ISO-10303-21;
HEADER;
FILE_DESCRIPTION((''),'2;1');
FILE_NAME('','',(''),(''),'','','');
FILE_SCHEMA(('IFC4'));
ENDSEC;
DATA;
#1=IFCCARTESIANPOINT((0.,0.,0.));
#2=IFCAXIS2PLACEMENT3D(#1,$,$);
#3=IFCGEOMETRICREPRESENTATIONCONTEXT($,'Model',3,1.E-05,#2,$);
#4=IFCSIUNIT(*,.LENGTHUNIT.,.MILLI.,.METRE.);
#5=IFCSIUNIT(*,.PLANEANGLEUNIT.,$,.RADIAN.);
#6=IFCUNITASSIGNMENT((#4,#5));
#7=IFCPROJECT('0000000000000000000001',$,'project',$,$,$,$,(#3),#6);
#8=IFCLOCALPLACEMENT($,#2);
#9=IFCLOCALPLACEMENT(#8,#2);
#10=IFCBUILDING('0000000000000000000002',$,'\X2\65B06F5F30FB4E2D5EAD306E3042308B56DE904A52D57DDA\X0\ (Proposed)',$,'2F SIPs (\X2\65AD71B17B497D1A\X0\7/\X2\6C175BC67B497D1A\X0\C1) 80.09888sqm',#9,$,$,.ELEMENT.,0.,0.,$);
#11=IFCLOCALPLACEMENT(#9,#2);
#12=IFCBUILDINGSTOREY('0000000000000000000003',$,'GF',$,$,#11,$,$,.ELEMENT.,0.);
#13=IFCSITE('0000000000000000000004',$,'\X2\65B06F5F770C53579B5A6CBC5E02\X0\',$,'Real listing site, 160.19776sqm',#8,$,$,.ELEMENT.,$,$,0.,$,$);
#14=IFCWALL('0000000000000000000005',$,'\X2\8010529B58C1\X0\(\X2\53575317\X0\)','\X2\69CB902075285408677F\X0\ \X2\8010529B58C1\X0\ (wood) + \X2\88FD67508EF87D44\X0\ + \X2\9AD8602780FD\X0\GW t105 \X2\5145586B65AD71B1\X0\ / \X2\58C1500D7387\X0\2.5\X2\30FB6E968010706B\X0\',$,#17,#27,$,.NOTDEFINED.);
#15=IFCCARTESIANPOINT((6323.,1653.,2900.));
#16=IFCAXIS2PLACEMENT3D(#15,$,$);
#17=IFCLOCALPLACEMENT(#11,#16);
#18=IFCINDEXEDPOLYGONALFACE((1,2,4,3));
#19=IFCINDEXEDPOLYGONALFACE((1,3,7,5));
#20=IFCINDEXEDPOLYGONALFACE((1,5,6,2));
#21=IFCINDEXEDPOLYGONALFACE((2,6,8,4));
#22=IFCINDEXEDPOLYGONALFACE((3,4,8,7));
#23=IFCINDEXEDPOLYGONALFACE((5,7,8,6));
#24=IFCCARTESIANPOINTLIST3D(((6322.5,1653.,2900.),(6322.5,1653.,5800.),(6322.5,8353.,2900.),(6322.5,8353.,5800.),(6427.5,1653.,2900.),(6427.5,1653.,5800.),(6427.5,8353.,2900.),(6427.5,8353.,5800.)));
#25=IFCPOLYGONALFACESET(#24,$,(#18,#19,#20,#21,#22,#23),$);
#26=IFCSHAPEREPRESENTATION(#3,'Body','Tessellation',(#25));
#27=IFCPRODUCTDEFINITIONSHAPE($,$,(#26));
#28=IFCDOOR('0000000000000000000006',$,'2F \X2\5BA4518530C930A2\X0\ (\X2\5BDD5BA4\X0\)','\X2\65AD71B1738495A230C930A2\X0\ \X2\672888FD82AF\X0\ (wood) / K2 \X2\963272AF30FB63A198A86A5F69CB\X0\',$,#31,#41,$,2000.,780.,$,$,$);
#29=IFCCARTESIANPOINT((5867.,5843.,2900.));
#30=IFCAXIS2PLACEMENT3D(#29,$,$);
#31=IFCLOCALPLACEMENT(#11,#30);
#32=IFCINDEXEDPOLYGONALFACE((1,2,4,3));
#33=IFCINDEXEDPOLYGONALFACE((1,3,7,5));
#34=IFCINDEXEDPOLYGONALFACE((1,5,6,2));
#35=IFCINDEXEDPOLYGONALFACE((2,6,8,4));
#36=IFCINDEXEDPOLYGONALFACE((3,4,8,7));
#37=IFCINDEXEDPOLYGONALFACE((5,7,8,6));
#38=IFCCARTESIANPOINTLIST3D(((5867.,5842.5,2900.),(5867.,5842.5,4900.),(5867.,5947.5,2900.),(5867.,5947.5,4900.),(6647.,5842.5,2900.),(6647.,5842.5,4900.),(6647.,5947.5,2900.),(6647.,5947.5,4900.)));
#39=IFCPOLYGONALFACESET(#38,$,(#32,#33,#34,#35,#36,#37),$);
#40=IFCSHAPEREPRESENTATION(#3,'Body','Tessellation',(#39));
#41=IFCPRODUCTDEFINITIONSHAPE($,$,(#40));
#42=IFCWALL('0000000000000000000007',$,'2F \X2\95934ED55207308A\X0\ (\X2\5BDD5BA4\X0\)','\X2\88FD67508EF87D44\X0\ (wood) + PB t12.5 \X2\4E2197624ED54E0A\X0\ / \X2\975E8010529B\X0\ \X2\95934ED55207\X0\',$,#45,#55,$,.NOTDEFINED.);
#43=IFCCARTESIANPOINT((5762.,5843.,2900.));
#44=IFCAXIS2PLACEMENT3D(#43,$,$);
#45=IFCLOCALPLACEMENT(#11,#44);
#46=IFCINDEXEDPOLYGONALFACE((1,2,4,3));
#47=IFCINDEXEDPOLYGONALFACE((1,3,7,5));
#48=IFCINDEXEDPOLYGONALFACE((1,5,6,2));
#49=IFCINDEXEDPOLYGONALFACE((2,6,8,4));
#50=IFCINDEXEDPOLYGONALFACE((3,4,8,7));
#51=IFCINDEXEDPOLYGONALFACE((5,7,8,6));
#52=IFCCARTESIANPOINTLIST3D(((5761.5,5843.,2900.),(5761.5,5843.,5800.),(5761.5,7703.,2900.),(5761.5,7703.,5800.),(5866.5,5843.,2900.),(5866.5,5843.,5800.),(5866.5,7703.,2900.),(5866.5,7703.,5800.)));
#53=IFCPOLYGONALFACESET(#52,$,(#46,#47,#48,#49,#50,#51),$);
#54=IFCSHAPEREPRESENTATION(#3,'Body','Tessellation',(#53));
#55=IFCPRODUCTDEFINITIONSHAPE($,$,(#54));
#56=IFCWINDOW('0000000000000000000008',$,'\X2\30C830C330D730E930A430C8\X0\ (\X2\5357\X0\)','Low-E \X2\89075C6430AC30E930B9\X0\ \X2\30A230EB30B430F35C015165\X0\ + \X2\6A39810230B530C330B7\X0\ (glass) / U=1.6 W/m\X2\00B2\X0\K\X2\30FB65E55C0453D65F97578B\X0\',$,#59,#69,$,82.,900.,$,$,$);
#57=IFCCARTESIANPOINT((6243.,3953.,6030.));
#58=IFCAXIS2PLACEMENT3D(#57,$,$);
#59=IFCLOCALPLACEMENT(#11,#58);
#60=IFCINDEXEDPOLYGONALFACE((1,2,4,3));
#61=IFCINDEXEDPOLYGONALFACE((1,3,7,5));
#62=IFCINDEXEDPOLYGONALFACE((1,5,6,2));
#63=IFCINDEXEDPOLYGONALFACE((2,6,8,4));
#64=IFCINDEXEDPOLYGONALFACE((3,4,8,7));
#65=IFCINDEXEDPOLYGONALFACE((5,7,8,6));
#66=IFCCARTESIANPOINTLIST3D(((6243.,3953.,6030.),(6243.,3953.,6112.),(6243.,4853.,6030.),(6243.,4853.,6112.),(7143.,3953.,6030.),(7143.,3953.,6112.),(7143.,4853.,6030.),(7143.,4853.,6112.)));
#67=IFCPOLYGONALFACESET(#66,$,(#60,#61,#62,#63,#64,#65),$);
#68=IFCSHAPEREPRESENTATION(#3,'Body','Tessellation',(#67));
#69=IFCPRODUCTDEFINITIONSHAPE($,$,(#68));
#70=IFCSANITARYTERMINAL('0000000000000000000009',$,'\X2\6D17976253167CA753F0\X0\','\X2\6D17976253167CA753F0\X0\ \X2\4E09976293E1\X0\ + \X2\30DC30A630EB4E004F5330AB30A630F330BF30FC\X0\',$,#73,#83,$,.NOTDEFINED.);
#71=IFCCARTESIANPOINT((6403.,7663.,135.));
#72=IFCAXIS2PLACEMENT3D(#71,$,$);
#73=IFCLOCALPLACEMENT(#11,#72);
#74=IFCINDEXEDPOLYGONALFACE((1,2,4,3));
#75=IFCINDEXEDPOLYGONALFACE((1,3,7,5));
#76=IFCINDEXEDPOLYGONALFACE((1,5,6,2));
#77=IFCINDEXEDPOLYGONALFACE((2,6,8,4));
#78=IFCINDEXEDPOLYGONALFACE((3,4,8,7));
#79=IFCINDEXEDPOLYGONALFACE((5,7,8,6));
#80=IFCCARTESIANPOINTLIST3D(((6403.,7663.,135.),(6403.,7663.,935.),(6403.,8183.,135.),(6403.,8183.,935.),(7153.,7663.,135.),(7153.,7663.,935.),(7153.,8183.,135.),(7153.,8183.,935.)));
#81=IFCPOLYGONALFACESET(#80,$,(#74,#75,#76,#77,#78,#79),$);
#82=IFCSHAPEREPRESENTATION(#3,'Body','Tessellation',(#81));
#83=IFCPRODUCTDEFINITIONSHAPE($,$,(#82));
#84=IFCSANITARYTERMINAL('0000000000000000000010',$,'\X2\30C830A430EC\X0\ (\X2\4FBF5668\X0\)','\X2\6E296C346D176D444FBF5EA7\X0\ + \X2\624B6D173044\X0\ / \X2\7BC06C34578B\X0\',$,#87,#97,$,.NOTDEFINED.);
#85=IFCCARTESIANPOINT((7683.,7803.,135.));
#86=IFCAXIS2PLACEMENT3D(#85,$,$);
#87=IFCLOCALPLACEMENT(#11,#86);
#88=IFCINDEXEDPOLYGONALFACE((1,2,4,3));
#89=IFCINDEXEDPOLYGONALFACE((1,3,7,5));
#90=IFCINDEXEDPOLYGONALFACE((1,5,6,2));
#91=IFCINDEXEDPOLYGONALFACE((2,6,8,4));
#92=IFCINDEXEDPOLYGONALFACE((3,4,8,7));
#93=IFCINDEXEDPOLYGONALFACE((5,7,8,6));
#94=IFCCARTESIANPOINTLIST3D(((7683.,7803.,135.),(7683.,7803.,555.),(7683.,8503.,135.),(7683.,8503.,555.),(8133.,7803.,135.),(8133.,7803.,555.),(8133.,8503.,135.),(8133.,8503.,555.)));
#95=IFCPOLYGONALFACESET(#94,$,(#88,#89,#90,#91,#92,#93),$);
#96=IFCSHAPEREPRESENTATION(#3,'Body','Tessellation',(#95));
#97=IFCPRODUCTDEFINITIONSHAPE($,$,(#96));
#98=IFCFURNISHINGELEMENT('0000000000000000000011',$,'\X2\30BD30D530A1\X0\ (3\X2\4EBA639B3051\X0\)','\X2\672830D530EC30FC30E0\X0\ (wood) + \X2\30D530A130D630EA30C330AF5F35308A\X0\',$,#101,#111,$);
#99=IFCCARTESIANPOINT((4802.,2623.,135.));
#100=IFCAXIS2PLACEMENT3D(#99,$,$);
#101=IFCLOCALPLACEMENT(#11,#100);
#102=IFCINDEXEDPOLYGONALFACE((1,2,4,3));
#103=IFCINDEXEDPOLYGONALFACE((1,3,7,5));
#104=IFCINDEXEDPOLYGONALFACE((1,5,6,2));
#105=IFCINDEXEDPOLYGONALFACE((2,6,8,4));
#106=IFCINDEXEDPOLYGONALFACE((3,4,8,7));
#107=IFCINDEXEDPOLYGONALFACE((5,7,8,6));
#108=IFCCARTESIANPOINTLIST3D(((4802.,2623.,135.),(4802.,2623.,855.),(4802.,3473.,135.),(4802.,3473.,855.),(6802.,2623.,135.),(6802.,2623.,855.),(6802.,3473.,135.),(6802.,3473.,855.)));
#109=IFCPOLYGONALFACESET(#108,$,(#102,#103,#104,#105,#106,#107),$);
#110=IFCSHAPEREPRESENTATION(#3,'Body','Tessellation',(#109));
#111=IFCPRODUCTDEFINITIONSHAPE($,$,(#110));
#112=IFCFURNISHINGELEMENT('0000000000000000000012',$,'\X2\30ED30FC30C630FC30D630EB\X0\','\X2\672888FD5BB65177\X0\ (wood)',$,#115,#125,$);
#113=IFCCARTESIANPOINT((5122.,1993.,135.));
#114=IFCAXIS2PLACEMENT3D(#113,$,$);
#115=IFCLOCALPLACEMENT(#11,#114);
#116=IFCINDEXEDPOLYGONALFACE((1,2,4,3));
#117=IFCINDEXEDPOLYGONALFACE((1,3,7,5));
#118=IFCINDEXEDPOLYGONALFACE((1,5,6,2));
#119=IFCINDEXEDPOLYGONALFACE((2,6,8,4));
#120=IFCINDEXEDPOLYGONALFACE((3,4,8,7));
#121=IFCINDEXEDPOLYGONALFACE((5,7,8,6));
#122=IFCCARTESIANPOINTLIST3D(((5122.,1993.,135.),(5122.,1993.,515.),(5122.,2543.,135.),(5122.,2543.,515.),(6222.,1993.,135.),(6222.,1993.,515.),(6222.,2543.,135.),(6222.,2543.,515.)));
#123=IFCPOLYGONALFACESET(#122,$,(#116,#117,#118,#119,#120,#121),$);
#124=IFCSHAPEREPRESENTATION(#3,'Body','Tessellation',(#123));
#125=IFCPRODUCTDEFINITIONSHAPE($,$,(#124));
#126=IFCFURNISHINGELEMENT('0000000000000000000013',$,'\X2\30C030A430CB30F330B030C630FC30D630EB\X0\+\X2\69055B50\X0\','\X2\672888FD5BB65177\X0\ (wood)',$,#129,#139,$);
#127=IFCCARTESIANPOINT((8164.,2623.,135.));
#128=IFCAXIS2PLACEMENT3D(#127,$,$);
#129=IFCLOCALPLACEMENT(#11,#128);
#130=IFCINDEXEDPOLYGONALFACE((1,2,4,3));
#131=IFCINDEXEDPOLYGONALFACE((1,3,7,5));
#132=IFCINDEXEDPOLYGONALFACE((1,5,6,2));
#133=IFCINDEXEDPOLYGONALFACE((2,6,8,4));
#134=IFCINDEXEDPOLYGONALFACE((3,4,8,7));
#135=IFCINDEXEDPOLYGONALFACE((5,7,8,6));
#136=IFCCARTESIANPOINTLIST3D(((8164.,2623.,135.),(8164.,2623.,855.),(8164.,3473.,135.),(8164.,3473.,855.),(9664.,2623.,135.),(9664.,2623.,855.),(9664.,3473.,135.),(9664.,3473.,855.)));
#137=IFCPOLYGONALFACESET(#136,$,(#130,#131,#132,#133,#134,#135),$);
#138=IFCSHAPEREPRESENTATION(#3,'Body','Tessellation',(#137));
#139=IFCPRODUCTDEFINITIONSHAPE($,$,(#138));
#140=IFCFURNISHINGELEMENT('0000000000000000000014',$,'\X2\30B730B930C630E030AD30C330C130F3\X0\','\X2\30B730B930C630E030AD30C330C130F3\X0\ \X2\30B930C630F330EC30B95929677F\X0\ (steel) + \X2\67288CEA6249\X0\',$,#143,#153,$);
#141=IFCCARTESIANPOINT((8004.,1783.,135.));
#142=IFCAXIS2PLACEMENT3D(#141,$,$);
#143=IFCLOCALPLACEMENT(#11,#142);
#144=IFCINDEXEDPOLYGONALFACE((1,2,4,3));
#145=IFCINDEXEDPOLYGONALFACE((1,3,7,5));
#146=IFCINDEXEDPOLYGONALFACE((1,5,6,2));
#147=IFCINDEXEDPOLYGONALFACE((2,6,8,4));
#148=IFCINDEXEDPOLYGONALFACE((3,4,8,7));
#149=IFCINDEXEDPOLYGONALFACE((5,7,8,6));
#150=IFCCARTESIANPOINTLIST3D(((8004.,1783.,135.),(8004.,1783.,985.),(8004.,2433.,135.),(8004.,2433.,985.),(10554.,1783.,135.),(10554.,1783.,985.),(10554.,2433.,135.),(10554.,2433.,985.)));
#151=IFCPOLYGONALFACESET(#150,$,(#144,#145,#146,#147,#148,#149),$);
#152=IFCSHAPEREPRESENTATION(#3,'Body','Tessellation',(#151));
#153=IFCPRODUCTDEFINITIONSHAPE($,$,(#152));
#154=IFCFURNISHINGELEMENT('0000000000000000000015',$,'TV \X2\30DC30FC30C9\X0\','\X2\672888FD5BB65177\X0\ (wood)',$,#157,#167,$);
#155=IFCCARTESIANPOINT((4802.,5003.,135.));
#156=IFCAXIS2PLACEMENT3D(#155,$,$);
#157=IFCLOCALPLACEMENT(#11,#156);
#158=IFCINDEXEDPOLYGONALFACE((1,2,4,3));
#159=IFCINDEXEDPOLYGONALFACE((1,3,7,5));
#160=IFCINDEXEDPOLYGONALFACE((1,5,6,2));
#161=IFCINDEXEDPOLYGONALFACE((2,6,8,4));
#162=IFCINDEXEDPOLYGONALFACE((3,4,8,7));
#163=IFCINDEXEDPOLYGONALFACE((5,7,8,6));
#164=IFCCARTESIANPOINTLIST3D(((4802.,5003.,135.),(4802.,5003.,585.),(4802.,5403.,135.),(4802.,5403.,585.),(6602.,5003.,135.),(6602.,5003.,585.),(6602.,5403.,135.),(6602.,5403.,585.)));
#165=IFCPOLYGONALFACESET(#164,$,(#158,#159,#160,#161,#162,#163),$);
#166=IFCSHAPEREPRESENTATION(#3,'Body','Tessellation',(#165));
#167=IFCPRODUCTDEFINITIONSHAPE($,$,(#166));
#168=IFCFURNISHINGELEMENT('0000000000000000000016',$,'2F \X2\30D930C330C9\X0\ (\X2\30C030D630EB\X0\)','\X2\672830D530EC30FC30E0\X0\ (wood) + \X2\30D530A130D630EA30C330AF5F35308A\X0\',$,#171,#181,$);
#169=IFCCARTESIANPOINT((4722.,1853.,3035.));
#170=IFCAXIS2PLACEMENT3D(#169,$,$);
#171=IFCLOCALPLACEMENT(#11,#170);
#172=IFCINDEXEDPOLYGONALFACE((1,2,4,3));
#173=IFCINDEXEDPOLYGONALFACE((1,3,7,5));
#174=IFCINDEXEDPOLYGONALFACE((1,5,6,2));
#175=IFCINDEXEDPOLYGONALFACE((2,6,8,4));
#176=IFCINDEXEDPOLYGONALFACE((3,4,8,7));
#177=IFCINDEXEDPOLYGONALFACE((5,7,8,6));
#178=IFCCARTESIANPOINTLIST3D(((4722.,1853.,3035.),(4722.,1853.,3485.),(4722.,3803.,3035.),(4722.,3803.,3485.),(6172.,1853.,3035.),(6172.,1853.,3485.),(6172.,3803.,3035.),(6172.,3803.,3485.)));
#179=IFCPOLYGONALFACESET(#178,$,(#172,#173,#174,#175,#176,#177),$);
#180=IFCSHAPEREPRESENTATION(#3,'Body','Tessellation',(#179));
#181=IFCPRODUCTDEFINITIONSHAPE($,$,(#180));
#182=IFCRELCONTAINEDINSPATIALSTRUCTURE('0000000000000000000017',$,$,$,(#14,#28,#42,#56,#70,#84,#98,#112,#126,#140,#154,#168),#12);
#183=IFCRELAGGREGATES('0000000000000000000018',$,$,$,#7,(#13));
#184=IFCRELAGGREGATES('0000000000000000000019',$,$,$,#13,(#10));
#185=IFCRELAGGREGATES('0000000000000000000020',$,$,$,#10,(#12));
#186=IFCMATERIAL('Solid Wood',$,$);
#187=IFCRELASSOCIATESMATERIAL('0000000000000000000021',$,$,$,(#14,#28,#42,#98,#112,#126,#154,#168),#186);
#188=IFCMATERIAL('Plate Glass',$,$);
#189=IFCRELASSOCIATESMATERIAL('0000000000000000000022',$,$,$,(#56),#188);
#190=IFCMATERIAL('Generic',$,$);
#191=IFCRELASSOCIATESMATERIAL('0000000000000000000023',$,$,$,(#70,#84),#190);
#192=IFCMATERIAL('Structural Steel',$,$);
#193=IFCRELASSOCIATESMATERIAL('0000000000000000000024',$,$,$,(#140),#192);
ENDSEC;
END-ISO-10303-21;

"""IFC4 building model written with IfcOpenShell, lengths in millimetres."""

from ifc_helpers import new_model, si_unit, frame, frame_2d, origin, place, context, project, spatial, rectangle, extrude, material, element, fill, save


model = new_model("IFC4")

# Units and contexts
model_context = context("Model", 3, precision=1e-05, world=origin())
ifc_project = project(units=[si_unit("LENGTHUNIT", "METRE", prefix="MILLI"), si_unit("PLANEANGLEUNIT", "RADIAN")], contexts=[model_context])

# Site, building, storey
site_placement = place(None, origin())
site = spatial("IfcSite", under=ifc_project, at=site_placement, Name="新潟県南魚沼市", ObjectType="Real listing site, 160.19776sqm", CompositionType="ELEMENT", RefElevation=0.0)
building_placement = place(site_placement, origin())
building = spatial("IfcBuilding", under=site, at=building_placement, Name="新潟・中庭のある回遊動線 (Proposed)", ObjectType="2F SIPs (断熱等級7/気密等級C1) 80.09888sqm", CompositionType="ELEMENT", ElevationOfRefHeight=0.0, ElevationOfTerrain=0.0)
storey_placement = place(building_placement, origin())
storey = spatial("IfcBuildingStorey", under=building, at=storey_placement, Name="GF", CompositionType="ELEMENT", Elevation=0.0)

# Shared definitions
ifc_material_1 = material(Name="Solid Wood")

# Wall, opening, door
wall_1_placement = place(storey_placement, frame((6323.0, 1653.0, 2900.0)))
wall_1 = element("IfcWall", 1, at=wall_1_placement, inside=storey, material=ifc_material_1, Name="耐力壁(南北)", Description="構造用合板 耐力壁 (wood) + 製材軸組 + 高性能GW t105 充填断熱 / 壁倍率2.5・準耐火", PredefinedType="NOTDEFINED", context=model_context, shape_type="SweptSolid", body=[
    extrude(rectangle(XDim=105.0, YDim=6700.0, at=frame_2d((52.0, 3350.0))), frame((6323.0, 1653.0, 2900.0)), (0.0, 0.0, 1.0), 2900.0),
])
opening_1_placement = place(storey_placement, frame((5867.0, 5843.0, 2900.0)))
opening_1 = element("IfcOpeningElement", 2, at=opening_1_placement, cuts=wall_1, PredefinedType="NOTDEFINED", context=model_context, shape_type="SweptSolid", body=[
    extrude(rectangle(XDim=780.0, YDim=105.0, at=frame_2d((390.0, 52.0))), frame((5867.0, 5843.0, 2900.0)), (0.0, 0.0, 1.0), 2000.0),
])
door_1_placement = place(storey_placement, frame((5867.0, 5843.0, 2900.0)))
door_1 = element("IfcDoor", 3, at=door_1_placement, inside=storey, material=ifc_material_1, Name="2F 室内ドア (寝室)", Description="断熱玄関ドア 木製芯 (wood) / K2 防犯・採風機構", OverallHeight=2000.0, OverallWidth=780.0, context=model_context, shape_type="SweptSolid", body=[
    extrude(rectangle(XDim=780.0, YDim=105.0, at=frame_2d((390.0, 52.0))), frame((5867.0, 5843.0, 2900.0)), (0.0, 0.0, 1.0), 2000.0),
])
fill(opening_1, door_1)

# Wall
wall_2_placement = place(storey_placement, frame((5762.0, 5843.0, 2900.0)))
element("IfcWall", 4, at=wall_2_placement, inside=storey, material=ifc_material_1, Name="2F 間仕切り (寝室)", Description="製材軸組 (wood) + PB t12.5 両面仕上 / 非耐力 間仕切", PredefinedType="NOTDEFINED", context=model_context, shape_type="SweptSolid", body=[
    extrude(rectangle(XDim=105.0, YDim=1860.0, at=frame_2d((52.0, 930.0))), frame((5762.0, 5843.0, 2900.0)), (0.0, 0.0, 1.0), 2900.0),
])

# Window
ifc_material_2 = material(Name="Plate Glass")
window_placement = place(storey_placement, frame((6243.0, 3953.0, 6030.0)))
element("IfcWindow", 5, at=window_placement, inside=storey, material=ifc_material_2, Name="トップライト (南)", Description="Low-E 複層ガラス アルゴン封入 + 樹脂サッシ (glass) / U=1.6 W/m²K・日射取得型", OverallHeight=82.0, OverallWidth=900.0, context=model_context, shape_type="SweptSolid", body=[
    extrude(rectangle(XDim=900.0, YDim=900.0, at=frame_2d((450.0, 450.0))), frame((6243.0, 3953.0, 6030.0)), (0.0, 0.0, 1.0), 82.0),
])

# Sanitary terminals
ifc_material_3 = material(Name="Generic")
sanitary_terminal_1_placement = place(storey_placement, frame((6403.0, 7663.0, 135.0)))
element("IfcSanitaryTerminal", 6, at=sanitary_terminal_1_placement, inside=storey, material=ifc_material_3, Name="洗面化粧台", Description="洗面化粧台 三面鏡 + ボウル一体カウンター", PredefinedType="NOTDEFINED", context=model_context, shape_type="SweptSolid", body=[
    extrude(rectangle(XDim=750.0, YDim=520.0, at=frame_2d((375.0, 260.0))), frame((6403.0, 7663.0, 135.0)), (0.0, 0.0, 1.0), 800.0),
])
sanitary_terminal_2_placement = place(storey_placement, frame((7683.0, 7803.0, 135.0)))
element("IfcSanitaryTerminal", 7, at=sanitary_terminal_2_placement, inside=storey, material=ifc_material_3, Name="トイレ (便器)", Description="温水洗浄便座 + 手洗い / 節水型", PredefinedType="NOTDEFINED", context=model_context, shape_type="SweptSolid", body=[
    extrude(rectangle(XDim=450.0, YDim=700.0, at=frame_2d((225.0, 350.0))), frame((7683.0, 7803.0, 135.0)), (0.0, 0.0, 1.0), 420.0),
])

# Furnishing elements
furnishing_1_placement = place(storey_placement, frame((4802.0, 2623.0, 135.0)))
element("IfcFurnishingElement", 8, at=furnishing_1_placement, inside=storey, material=ifc_material_1, Name="ソファ (3人掛け)", Description="木フレーム (wood) + ファブリック張り", context=model_context, shape_type="SweptSolid", body=[
    extrude(rectangle(XDim=2000.0, YDim=850.0, at=frame_2d((1000.0, 425.0))), frame((4802.0, 2623.0, 135.0)), (0.0, 0.0, 1.0), 720.0),
])
furnishing_2_placement = place(storey_placement, frame((5122.0, 1993.0, 135.0)))
element("IfcFurnishingElement", 9, at=furnishing_2_placement, inside=storey, material=ifc_material_1, Name="ローテーブル", Description="木製家具 (wood)", context=model_context, shape_type="SweptSolid", body=[
    extrude(rectangle(XDim=1100.0, YDim=550.0, at=frame_2d((550.0, 275.0))), frame((5122.0, 1993.0, 135.0)), (0.0, 0.0, 1.0), 380.0),
])
furnishing_3_placement = place(storey_placement, frame((8164.0, 2623.0, 135.0)))
element("IfcFurnishingElement", 10, at=furnishing_3_placement, inside=storey, material=ifc_material_1, Name="ダイニングテーブル+椅子", Description="木製家具 (wood)", context=model_context, shape_type="SweptSolid", body=[
    extrude(rectangle(XDim=1500.0, YDim=850.0, at=frame_2d((750.0, 425.0))), frame((8164.0, 2623.0, 135.0)), (0.0, 0.0, 1.0), 720.0),
])
ifc_material_4 = material(Name="Structural Steel")
furnishing_4_placement = place(storey_placement, frame((8004.0, 1783.0, 135.0)))
element("IfcFurnishingElement", 11, at=furnishing_4_placement, inside=storey, material=ifc_material_4, Name="システムキッチン", Description="システムキッチン ステンレス天板 (steel) + 木質扉", context=model_context, shape_type="SweptSolid", body=[
    extrude(rectangle(XDim=2550.0, YDim=650.0, at=frame_2d((1275.0, 325.0))), frame((8004.0, 1783.0, 135.0)), (0.0, 0.0, 1.0), 850.0),
])
furnishing_5_placement = place(storey_placement, frame((4802.0, 5003.0, 135.0)))
element("IfcFurnishingElement", 12, at=furnishing_5_placement, inside=storey, material=ifc_material_1, Name="TV ボード", Description="木製家具 (wood)", context=model_context, shape_type="SweptSolid", body=[
    extrude(rectangle(XDim=1800.0, YDim=400.0, at=frame_2d((900.0, 200.0))), frame((4802.0, 5003.0, 135.0)), (0.0, 0.0, 1.0), 450.0),
])
furnishing_6_placement = place(storey_placement, frame((4722.0, 1853.0, 3035.0)))
element("IfcFurnishingElement", 13, at=furnishing_6_placement, inside=storey, material=ifc_material_1, Name="2F ベッド (ダブル)", Description="木フレーム (wood) + ファブリック張り", context=model_context, shape_type="SweptSolid", body=[
    extrude(rectangle(XDim=1450.0, YDim=1950.0, at=frame_2d((725.0, 975.0))), frame((4722.0, 1853.0, 3035.0)), (0.0, 0.0, 1.0), 450.0),
])

save(model, "model.ifc")
